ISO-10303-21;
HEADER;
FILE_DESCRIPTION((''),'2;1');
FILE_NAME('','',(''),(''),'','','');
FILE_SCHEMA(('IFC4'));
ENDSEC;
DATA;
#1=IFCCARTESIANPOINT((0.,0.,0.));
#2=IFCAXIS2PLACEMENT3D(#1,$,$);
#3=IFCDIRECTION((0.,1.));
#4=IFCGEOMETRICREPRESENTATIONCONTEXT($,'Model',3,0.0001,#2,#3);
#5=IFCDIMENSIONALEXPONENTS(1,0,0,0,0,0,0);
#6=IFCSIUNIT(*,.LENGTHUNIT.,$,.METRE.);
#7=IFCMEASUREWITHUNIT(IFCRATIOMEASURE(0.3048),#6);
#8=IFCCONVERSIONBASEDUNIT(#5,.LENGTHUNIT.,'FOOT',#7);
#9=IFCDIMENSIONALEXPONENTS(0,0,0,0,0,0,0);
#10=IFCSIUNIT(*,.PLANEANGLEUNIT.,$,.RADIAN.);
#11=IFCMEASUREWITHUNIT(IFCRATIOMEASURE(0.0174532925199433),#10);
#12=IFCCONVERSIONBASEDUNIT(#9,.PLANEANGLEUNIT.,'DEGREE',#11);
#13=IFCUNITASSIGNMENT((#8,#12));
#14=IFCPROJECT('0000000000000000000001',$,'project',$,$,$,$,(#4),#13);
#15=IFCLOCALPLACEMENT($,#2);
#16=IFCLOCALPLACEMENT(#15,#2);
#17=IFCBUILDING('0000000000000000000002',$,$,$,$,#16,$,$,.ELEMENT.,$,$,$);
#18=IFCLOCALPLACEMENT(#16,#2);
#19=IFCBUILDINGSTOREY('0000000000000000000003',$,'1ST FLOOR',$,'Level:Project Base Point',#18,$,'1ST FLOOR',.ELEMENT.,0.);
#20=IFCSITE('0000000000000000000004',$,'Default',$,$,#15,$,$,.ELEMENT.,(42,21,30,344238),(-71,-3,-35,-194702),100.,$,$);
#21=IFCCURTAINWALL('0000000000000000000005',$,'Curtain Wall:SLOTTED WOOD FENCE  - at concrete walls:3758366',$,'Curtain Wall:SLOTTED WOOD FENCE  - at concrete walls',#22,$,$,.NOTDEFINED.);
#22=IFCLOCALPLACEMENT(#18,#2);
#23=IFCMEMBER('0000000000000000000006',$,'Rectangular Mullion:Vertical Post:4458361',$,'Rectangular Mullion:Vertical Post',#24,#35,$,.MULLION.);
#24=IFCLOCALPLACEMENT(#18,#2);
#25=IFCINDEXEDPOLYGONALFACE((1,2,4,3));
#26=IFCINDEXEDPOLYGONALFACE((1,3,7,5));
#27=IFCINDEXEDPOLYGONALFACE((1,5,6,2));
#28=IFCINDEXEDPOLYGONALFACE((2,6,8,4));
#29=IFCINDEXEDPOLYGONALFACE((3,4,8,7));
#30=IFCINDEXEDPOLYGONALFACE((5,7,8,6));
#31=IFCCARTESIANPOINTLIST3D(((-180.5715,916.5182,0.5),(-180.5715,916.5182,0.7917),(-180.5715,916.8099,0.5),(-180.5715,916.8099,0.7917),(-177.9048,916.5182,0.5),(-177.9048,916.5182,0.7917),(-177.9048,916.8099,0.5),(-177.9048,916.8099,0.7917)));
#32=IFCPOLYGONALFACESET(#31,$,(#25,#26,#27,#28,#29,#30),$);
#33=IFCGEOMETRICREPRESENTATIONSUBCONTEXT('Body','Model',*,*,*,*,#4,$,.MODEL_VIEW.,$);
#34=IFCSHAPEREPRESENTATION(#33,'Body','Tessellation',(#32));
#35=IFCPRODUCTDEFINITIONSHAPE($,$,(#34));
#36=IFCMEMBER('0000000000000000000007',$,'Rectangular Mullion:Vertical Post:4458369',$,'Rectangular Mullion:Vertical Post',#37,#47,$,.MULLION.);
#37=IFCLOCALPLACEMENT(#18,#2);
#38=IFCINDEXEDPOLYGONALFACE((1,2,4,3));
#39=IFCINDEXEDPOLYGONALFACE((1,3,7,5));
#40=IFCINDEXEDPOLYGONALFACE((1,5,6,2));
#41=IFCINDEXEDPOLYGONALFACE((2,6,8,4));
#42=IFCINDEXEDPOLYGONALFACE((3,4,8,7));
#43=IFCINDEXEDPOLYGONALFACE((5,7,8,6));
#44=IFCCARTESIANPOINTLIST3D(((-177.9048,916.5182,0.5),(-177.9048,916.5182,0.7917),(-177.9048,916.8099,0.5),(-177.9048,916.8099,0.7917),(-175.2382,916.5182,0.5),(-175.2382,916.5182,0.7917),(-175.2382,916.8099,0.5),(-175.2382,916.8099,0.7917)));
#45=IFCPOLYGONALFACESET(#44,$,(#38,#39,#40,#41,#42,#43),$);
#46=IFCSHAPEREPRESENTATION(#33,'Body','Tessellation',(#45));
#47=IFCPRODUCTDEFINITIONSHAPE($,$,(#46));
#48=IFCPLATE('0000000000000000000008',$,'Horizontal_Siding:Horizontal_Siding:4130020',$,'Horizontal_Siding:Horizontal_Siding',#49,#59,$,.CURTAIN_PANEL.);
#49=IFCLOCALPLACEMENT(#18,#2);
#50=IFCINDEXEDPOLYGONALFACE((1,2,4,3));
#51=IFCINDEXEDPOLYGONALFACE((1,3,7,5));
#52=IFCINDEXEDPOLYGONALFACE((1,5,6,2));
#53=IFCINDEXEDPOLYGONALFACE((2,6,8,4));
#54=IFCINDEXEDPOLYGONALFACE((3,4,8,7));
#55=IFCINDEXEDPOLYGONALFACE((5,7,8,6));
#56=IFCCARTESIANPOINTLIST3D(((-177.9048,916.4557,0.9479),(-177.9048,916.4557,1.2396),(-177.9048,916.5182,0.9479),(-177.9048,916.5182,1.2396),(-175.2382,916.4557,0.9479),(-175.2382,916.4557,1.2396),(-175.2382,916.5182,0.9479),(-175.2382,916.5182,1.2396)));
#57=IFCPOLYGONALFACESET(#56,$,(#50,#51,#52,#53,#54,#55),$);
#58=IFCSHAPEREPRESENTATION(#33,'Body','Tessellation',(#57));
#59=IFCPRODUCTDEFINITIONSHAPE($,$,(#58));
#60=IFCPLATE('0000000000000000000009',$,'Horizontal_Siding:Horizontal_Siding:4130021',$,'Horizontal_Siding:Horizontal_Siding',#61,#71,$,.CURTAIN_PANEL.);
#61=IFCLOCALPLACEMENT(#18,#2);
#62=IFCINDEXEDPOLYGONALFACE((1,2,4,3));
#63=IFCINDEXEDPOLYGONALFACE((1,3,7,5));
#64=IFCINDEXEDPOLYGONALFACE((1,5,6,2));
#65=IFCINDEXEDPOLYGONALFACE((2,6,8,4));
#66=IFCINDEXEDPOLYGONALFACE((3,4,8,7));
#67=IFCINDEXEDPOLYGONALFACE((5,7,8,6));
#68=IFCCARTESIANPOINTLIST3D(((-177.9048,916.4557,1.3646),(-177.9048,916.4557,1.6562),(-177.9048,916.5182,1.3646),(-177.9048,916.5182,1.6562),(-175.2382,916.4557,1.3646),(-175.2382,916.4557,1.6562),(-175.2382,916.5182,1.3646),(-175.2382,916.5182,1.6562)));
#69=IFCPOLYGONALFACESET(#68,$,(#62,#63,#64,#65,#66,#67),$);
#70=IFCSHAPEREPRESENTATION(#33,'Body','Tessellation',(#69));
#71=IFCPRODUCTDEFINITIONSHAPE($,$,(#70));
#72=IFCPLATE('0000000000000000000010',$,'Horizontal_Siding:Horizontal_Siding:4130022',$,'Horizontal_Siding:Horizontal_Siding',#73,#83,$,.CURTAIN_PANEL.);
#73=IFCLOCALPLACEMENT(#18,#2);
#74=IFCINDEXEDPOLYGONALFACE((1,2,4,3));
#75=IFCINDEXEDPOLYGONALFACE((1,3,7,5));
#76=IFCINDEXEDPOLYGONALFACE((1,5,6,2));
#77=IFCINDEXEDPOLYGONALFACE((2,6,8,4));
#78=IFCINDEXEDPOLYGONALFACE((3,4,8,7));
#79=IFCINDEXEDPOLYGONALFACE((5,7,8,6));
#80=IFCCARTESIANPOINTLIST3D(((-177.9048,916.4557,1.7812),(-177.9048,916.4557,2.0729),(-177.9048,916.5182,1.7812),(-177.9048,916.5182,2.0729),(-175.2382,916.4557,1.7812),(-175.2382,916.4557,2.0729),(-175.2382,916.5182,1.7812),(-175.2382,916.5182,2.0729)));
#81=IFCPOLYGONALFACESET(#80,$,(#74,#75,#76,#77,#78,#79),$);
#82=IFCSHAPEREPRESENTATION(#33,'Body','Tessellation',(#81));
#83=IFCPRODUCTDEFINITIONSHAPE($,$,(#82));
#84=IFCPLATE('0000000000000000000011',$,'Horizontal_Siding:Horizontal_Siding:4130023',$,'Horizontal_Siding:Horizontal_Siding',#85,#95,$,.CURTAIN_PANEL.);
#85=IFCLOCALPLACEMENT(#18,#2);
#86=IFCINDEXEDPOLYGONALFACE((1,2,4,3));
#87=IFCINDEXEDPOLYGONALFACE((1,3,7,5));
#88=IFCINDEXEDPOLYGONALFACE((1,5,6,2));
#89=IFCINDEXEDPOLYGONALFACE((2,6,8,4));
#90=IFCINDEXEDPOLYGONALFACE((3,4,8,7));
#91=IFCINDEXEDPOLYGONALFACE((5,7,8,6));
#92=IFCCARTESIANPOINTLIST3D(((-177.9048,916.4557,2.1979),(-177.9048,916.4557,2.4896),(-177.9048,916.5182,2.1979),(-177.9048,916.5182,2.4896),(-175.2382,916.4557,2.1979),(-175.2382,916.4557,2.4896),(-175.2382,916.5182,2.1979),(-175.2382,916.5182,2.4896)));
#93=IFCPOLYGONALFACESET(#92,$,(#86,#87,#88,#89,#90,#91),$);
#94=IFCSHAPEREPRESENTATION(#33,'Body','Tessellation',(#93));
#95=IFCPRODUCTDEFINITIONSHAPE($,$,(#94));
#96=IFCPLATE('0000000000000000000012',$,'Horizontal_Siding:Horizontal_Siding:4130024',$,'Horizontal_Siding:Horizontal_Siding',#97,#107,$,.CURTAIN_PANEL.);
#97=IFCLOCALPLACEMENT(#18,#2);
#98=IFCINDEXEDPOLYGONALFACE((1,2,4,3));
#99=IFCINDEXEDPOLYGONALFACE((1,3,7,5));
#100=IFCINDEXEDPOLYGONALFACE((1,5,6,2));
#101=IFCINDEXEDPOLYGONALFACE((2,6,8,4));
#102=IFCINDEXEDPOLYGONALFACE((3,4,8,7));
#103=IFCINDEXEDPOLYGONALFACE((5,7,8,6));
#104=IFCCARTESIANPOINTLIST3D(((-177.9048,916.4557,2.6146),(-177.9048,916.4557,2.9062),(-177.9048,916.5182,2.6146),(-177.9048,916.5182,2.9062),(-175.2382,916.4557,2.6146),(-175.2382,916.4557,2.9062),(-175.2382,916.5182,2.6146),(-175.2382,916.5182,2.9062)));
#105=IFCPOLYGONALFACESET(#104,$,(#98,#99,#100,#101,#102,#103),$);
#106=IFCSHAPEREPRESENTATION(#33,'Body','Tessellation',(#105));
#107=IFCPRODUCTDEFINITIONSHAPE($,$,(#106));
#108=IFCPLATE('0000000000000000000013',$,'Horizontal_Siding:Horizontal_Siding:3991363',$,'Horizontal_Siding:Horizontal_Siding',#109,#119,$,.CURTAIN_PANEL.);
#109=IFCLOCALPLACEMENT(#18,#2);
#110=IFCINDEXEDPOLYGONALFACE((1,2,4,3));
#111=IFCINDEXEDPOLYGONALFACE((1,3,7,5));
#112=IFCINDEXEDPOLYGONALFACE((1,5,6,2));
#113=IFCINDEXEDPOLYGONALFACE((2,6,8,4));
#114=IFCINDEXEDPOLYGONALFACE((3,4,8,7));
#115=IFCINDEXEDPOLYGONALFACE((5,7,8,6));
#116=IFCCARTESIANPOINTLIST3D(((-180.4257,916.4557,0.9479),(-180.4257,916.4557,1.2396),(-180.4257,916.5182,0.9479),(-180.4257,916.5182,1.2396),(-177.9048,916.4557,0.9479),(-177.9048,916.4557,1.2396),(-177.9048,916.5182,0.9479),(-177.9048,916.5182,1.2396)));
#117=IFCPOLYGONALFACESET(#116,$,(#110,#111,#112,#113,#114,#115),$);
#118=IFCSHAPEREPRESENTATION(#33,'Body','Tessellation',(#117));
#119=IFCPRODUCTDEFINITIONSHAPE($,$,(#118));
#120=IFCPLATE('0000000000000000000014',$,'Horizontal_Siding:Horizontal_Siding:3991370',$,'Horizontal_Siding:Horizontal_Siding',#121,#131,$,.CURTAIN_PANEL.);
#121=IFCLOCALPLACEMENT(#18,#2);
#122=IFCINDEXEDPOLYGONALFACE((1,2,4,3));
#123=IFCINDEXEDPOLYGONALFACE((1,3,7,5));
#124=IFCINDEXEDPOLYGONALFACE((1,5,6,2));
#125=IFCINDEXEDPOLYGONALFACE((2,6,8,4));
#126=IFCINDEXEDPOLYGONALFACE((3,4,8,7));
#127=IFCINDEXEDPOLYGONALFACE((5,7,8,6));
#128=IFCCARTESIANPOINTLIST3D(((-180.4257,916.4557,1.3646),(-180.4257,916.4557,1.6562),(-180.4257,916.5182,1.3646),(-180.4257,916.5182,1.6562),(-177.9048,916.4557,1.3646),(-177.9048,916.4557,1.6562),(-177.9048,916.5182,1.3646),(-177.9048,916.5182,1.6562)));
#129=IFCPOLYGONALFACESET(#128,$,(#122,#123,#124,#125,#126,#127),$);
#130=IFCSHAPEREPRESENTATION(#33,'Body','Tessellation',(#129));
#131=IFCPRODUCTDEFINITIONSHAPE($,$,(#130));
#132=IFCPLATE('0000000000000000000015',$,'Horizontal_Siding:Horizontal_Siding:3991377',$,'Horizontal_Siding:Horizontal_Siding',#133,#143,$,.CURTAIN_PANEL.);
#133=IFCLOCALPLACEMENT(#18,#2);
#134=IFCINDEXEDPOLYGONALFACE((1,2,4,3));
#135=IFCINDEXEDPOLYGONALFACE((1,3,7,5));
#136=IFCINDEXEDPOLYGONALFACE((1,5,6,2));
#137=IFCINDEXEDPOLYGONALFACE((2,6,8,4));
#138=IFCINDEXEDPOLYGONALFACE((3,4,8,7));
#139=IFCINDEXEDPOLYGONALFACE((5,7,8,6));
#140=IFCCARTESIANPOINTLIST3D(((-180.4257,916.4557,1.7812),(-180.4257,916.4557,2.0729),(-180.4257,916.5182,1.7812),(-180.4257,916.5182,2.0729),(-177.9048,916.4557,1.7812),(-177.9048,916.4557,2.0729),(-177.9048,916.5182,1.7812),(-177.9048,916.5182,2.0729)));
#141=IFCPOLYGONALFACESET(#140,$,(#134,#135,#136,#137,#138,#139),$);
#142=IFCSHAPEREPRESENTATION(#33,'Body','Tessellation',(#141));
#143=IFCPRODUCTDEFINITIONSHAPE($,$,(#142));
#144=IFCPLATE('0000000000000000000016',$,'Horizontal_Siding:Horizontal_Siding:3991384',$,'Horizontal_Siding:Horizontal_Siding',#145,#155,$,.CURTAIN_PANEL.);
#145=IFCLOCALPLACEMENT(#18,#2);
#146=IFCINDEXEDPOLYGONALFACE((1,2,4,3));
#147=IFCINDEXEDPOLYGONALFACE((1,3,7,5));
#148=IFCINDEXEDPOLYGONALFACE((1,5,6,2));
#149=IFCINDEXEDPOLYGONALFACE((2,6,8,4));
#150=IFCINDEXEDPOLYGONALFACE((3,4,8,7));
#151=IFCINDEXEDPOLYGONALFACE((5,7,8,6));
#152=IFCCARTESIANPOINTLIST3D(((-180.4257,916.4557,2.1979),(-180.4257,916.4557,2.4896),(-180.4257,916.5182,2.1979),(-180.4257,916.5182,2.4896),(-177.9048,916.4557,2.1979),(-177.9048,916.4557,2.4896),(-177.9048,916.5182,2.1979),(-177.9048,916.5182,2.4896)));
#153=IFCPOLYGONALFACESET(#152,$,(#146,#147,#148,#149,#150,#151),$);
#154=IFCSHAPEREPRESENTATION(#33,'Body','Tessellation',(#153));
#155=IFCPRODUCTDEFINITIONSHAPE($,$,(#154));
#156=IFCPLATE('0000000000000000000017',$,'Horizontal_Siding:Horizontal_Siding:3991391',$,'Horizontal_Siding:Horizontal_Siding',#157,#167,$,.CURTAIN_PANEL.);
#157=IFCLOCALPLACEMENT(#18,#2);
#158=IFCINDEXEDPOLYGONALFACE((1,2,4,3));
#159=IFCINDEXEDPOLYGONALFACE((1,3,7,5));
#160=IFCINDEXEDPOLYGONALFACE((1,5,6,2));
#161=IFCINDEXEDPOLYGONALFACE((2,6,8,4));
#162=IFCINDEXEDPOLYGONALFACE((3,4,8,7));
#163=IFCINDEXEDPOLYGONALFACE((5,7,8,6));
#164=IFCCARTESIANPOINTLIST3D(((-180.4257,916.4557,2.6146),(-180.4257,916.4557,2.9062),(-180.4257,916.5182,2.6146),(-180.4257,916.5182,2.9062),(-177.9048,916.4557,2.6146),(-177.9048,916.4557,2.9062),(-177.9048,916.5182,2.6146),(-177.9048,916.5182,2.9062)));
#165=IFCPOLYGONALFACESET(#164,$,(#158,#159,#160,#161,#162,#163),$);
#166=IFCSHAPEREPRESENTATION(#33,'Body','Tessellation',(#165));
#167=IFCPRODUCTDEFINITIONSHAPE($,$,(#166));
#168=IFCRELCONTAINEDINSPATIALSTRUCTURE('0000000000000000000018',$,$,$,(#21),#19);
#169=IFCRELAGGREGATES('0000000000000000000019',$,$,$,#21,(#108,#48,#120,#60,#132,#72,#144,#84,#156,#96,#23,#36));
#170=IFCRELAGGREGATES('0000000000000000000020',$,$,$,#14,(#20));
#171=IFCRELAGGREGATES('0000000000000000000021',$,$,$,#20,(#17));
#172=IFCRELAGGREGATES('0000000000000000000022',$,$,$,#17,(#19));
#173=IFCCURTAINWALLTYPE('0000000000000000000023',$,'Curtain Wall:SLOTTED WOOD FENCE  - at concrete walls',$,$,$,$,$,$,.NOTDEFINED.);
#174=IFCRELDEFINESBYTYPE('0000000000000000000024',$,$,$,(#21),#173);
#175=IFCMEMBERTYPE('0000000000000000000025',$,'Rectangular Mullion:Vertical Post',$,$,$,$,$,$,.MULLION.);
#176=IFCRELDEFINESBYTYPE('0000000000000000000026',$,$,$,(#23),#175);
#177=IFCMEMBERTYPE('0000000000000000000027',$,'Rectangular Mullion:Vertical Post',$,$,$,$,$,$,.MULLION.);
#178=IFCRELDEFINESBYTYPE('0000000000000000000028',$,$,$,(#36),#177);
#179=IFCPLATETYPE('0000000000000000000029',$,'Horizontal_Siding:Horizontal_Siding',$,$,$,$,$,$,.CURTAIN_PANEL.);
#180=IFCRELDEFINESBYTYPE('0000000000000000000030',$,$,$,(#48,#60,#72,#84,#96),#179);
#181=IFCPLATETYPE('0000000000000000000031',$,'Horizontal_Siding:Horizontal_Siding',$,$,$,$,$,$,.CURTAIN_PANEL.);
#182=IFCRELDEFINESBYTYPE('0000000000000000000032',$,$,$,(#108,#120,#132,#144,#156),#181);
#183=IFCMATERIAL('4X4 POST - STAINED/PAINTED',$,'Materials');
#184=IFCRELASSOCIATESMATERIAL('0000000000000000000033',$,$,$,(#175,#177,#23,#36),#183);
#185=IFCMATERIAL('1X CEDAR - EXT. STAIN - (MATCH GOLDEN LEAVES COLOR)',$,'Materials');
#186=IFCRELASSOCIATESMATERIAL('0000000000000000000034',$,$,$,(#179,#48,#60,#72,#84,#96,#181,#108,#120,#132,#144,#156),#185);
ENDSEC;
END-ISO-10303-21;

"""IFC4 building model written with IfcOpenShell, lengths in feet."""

from ifc_helpers import new_model, entity, si_unit, converted_unit, direction, frame, origin, origin_2d_with_axis, place, context, subcontext, project, spatial, rectangle, extrude, source, transform, mapped, material, material_profile, profile_set, profile_usage, type_object, type_shapes, element, aggregate, save


model = new_model("IFC4")

# Units and contexts
model_context = context("Model", 3, precision=0.0001, world=origin(), true_north=direction((0.0, 1.0)))
body_context = subcontext(model_context, "Body", "Model", "MODEL_VIEW")
ifc_project = project(units=[converted_unit("LENGTHUNIT", "FOOT", entity("IfcRatioMeasure", 0.3048), si_unit("LENGTHUNIT", "METRE"), dimensions=[1, 0, 0, 0, 0, 0, 0]), converted_unit("PLANEANGLEUNIT", "DEGREE", entity("IfcRatioMeasure", 0.0174532925199433), si_unit("PLANEANGLEUNIT", "RADIAN"), dimensions=[0, 0, 0, 0, 0, 0, 0])], contexts=[model_context])

# Site, building, storey
site_placement = place(None, origin())
site = spatial("IfcSite", under=ifc_project, at=site_placement, Name="Default", CompositionType="ELEMENT", RefLatitude=(42, 21, 30, 344238), RefLongitude=(-71, -3, -35, -194702), RefElevation=100.0)
building_placement = place(site_placement, origin())
building = spatial("IfcBuilding", under=site, at=building_placement, CompositionType="ELEMENT")
storey_placement = place(building_placement, origin())
storey = spatial("IfcBuildingStorey", under=building, at=storey_placement, Name="1ST FLOOR", ObjectType="Level:Project Base Point", LongName="1ST FLOOR", CompositionType="ELEMENT", Elevation=0.0)

# Curtain wall, members, plates
curtain_wall_type = type_object("IfcCurtainWallType", Name="Curtain Wall:SLOTTED WOOD FENCE  - at concrete walls", PredefinedType="NOTDEFINED")
curtain_wall_placement = place(storey_placement, origin())
curtain_wall = element("IfcCurtainWall", 1, at=curtain_wall_placement, inside=storey, type_object=curtain_wall_type, Name="Curtain Wall:SLOTTED WOOD FENCE  - at concrete walls:3758366", ObjectType="Curtain Wall:SLOTTED WOOD FENCE  - at concrete walls", PredefinedType="NOTDEFINED")
ifc_material_1 = material(Name="4X4 POST - STAINED/PAINTED", Category="Materials")
ifc_material_profile = material_profile(ifc_material_1, rectangle(XDim=0.2917, YDim=0.2917, at=origin_2d_with_axis()), Name="Vertical Post")
ifc_profile_set = profile_set([ifc_material_profile], Name="Vertical Post")
ifc_profile_usage_1 = profile_usage(ifc_profile_set)
member_type_1 = type_object("IfcMemberType", Name="Rectangular Mullion:Vertical Post", PredefinedType="MULLION", material=ifc_profile_set)
shared_shape_1 = source(origin(), body_context, "Body", "SweptSolid", [
    extrude(rectangle(XDim=0.2917, YDim=0.2917, at=origin_2d_with_axis()), frame((-0.1458, -0.2083, -2.6667), z_axis=(0.0, 0.0, 1.0), x_axis=(0.0, -1.0, 0.0)), (0.0, 0.0, 1.0), 2.6667),
])
type_shapes(member_type_1, [shared_shape_1])
member_1_placement = place(storey_placement, frame((-180.5715, 916.4557, 0.5), z_axis=(-1.0, 0.0, 0.0), x_axis=(0.0, 0.0, -1.0)))
member_1 = element("IfcMember", 2, at=member_1_placement, type_object=member_type_1, material=ifc_profile_usage_1, Name="Rectangular Mullion:Vertical Post:4458361", ObjectType="Rectangular Mullion:Vertical Post", PredefinedType="MULLION", context=body_context, shape_type="MappedRepresentation", body=[
    mapped(shared_shape_1, transform((0.0, 0.0, 0.0), scale=1.0)),
])
ifc_profile_usage_2 = profile_usage(ifc_profile_set)
member_type_2 = type_object("IfcMemberType", Name="Rectangular Mullion:Vertical Post", PredefinedType="MULLION", material=ifc_profile_set)
shared_shape_2 = source(origin(), body_context, "Body", "SweptSolid", [
    extrude(rectangle(XDim=0.2917, YDim=0.2917, at=origin_2d_with_axis()), frame((-0.1458, -0.2083, -2.6667), z_axis=(0.0, 0.0, 1.0), x_axis=(0.0, -1.0, 0.0)), (0.0, 0.0, 1.0), 2.6667),
])
type_shapes(member_type_2, [shared_shape_2])
member_2_placement = place(storey_placement, frame((-177.9048, 916.4557, 0.5), z_axis=(-1.0, 0.0, 0.0), x_axis=(0.0, 0.0, -1.0)))
member_2 = element("IfcMember", 3, at=member_2_placement, type_object=member_type_2, material=ifc_profile_usage_2, Name="Rectangular Mullion:Vertical Post:4458369", ObjectType="Rectangular Mullion:Vertical Post", PredefinedType="MULLION", context=body_context, shape_type="MappedRepresentation", body=[
    mapped(shared_shape_2, transform((0.0, 0.0, 0.0), scale=1.0)),
])
ifc_material_2 = material(Name="1X CEDAR - EXT. STAIN - (MATCH GOLDEN LEAVES COLOR)", Category="Materials")
plate_type_1 = type_object("IfcPlateType", Name="Horizontal_Siding:Horizontal_Siding", PredefinedType="CURTAIN_PANEL", material=ifc_material_2)
shared_shape_3 = source(origin(), body_context, "Body", "SweptSolid", [
    extrude(rectangle(XDim=2.6667, YDim=0.0625, at=origin_2d_with_axis()), frame((1.3333, 0.0312, 0.0), z_axis=(0.0, 0.0, 1.0), x_axis=(-1.0, 0.0, 0.0)), (0.0, 0.0, 1.0), 0.2917),
])
type_shapes(plate_type_1, [shared_shape_3])
plate_1_placement = place(curtain_wall_placement, frame((-177.9048, 916.4557, 0.9479)))
plate_1 = element("IfcPlate", 4, at=plate_1_placement, type_object=plate_type_1, material=ifc_material_2, Name="Horizontal_Siding:Horizontal_Siding:4130020", ObjectType="Horizontal_Siding:Horizontal_Siding", PredefinedType="CURTAIN_PANEL", context=body_context, shape_type="MappedRepresentation", body=[
    mapped(shared_shape_3, transform((0.0, 0.0, 0.0), scale=1.0)),
])
plate_2_placement = place(curtain_wall_placement, frame((-177.9048, 916.4557, 1.3646)))
plate_2 = element("IfcPlate", 5, at=plate_2_placement, type_object=plate_type_1, material=ifc_material_2, Name="Horizontal_Siding:Horizontal_Siding:4130021", ObjectType="Horizontal_Siding:Horizontal_Siding", PredefinedType="CURTAIN_PANEL", context=body_context, shape_type="MappedRepresentation", body=[
    mapped(shared_shape_3, transform((0.0, 0.0, 0.0), scale=1.0)),
])
plate_3_placement = place(curtain_wall_placement, frame((-177.9048, 916.4557, 1.7812)))
plate_3 = element("IfcPlate", 6, at=plate_3_placement, type_object=plate_type_1, material=ifc_material_2, Name="Horizontal_Siding:Horizontal_Siding:4130022", ObjectType="Horizontal_Siding:Horizontal_Siding", PredefinedType="CURTAIN_PANEL", context=body_context, shape_type="MappedRepresentation", body=[
    mapped(shared_shape_3, transform((0.0, 0.0, 0.0), scale=1.0)),
])
plate_4_placement = place(curtain_wall_placement, frame((-177.9048, 916.4557, 2.1979)))
plate_4 = element("IfcPlate", 7, at=plate_4_placement, type_object=plate_type_1, material=ifc_material_2, Name="Horizontal_Siding:Horizontal_Siding:4130023", ObjectType="Horizontal_Siding:Horizontal_Siding", PredefinedType="CURTAIN_PANEL", context=body_context, shape_type="MappedRepresentation", body=[
    mapped(shared_shape_3, transform((0.0, 0.0, 0.0), scale=1.0)),
])
plate_5_placement = place(curtain_wall_placement, frame((-177.9048, 916.4557, 2.6146)))
plate_5 = element("IfcPlate", 8, at=plate_5_placement, type_object=plate_type_1, material=ifc_material_2, Name="Horizontal_Siding:Horizontal_Siding:4130024", ObjectType="Horizontal_Siding:Horizontal_Siding", PredefinedType="CURTAIN_PANEL", context=body_context, shape_type="MappedRepresentation", body=[
    mapped(shared_shape_3, transform((0.0, 0.0, 0.0), scale=1.0)),
])
plate_type_2 = type_object("IfcPlateType", Name="Horizontal_Siding:Horizontal_Siding", PredefinedType="CURTAIN_PANEL", material=ifc_material_2)
shared_shape_4 = source(origin(), body_context, "Body", "SweptSolid", [
    extrude(rectangle(XDim=2.5208, YDim=0.0625, at=origin_2d_with_axis()), frame((1.2604, 0.0312, 0.0), z_axis=(0.0, 0.0, 1.0), x_axis=(-1.0, 0.0, 0.0)), (0.0, 0.0, 1.0), 0.2917),
])
type_shapes(plate_type_2, [shared_shape_4])
plate_6_placement = place(curtain_wall_placement, frame((-180.4257, 916.4557, 0.9479)))
plate_6 = element("IfcPlate", 9, at=plate_6_placement, type_object=plate_type_2, material=ifc_material_2, Name="Horizontal_Siding:Horizontal_Siding:3991363", ObjectType="Horizontal_Siding:Horizontal_Siding", PredefinedType="CURTAIN_PANEL", context=body_context, shape_type="MappedRepresentation", body=[
    mapped(shared_shape_4, transform((0.0, 0.0, 0.0), scale=1.0)),
])
plate_7_placement = place(curtain_wall_placement, frame((-180.4257, 916.4557, 1.3646)))
plate_7 = element("IfcPlate", 10, at=plate_7_placement, type_object=plate_type_2, material=ifc_material_2, Name="Horizontal_Siding:Horizontal_Siding:3991370", ObjectType="Horizontal_Siding:Horizontal_Siding", PredefinedType="CURTAIN_PANEL", context=body_context, shape_type="MappedRepresentation", body=[
    mapped(shared_shape_4, transform((0.0, 0.0, 0.0), scale=1.0)),
])
plate_8_placement = place(curtain_wall_placement, frame((-180.4257, 916.4557, 1.7812)))
plate_8 = element("IfcPlate", 11, at=plate_8_placement, type_object=plate_type_2, material=ifc_material_2, Name="Horizontal_Siding:Horizontal_Siding:3991377", ObjectType="Horizontal_Siding:Horizontal_Siding", PredefinedType="CURTAIN_PANEL", context=body_context, shape_type="MappedRepresentation", body=[
    mapped(shared_shape_4, transform((0.0, 0.0, 0.0), scale=1.0)),
])
plate_9_placement = place(curtain_wall_placement, frame((-180.4257, 916.4557, 2.1979)))
plate_9 = element("IfcPlate", 12, at=plate_9_placement, type_object=plate_type_2, material=ifc_material_2, Name="Horizontal_Siding:Horizontal_Siding:3991384", ObjectType="Horizontal_Siding:Horizontal_Siding", PredefinedType="CURTAIN_PANEL", context=body_context, shape_type="MappedRepresentation", body=[
    mapped(shared_shape_4, transform((0.0, 0.0, 0.0), scale=1.0)),
])
plate_10_placement = place(curtain_wall_placement, frame((-180.4257, 916.4557, 2.6146)))
plate_10 = element("IfcPlate", 13, at=plate_10_placement, type_object=plate_type_2, material=ifc_material_2, Name="Horizontal_Siding:Horizontal_Siding:3991391", ObjectType="Horizontal_Siding:Horizontal_Siding", PredefinedType="CURTAIN_PANEL", context=body_context, shape_type="MappedRepresentation", body=[
    mapped(shared_shape_4, transform((0.0, 0.0, 0.0), scale=1.0)),
])
aggregate(curtain_wall, [plate_6, plate_1, plate_7, plate_2, plate_8, plate_3, plate_9, plate_4, plate_10, plate_5, member_1, member_2])

save(model, "model.ifc")
